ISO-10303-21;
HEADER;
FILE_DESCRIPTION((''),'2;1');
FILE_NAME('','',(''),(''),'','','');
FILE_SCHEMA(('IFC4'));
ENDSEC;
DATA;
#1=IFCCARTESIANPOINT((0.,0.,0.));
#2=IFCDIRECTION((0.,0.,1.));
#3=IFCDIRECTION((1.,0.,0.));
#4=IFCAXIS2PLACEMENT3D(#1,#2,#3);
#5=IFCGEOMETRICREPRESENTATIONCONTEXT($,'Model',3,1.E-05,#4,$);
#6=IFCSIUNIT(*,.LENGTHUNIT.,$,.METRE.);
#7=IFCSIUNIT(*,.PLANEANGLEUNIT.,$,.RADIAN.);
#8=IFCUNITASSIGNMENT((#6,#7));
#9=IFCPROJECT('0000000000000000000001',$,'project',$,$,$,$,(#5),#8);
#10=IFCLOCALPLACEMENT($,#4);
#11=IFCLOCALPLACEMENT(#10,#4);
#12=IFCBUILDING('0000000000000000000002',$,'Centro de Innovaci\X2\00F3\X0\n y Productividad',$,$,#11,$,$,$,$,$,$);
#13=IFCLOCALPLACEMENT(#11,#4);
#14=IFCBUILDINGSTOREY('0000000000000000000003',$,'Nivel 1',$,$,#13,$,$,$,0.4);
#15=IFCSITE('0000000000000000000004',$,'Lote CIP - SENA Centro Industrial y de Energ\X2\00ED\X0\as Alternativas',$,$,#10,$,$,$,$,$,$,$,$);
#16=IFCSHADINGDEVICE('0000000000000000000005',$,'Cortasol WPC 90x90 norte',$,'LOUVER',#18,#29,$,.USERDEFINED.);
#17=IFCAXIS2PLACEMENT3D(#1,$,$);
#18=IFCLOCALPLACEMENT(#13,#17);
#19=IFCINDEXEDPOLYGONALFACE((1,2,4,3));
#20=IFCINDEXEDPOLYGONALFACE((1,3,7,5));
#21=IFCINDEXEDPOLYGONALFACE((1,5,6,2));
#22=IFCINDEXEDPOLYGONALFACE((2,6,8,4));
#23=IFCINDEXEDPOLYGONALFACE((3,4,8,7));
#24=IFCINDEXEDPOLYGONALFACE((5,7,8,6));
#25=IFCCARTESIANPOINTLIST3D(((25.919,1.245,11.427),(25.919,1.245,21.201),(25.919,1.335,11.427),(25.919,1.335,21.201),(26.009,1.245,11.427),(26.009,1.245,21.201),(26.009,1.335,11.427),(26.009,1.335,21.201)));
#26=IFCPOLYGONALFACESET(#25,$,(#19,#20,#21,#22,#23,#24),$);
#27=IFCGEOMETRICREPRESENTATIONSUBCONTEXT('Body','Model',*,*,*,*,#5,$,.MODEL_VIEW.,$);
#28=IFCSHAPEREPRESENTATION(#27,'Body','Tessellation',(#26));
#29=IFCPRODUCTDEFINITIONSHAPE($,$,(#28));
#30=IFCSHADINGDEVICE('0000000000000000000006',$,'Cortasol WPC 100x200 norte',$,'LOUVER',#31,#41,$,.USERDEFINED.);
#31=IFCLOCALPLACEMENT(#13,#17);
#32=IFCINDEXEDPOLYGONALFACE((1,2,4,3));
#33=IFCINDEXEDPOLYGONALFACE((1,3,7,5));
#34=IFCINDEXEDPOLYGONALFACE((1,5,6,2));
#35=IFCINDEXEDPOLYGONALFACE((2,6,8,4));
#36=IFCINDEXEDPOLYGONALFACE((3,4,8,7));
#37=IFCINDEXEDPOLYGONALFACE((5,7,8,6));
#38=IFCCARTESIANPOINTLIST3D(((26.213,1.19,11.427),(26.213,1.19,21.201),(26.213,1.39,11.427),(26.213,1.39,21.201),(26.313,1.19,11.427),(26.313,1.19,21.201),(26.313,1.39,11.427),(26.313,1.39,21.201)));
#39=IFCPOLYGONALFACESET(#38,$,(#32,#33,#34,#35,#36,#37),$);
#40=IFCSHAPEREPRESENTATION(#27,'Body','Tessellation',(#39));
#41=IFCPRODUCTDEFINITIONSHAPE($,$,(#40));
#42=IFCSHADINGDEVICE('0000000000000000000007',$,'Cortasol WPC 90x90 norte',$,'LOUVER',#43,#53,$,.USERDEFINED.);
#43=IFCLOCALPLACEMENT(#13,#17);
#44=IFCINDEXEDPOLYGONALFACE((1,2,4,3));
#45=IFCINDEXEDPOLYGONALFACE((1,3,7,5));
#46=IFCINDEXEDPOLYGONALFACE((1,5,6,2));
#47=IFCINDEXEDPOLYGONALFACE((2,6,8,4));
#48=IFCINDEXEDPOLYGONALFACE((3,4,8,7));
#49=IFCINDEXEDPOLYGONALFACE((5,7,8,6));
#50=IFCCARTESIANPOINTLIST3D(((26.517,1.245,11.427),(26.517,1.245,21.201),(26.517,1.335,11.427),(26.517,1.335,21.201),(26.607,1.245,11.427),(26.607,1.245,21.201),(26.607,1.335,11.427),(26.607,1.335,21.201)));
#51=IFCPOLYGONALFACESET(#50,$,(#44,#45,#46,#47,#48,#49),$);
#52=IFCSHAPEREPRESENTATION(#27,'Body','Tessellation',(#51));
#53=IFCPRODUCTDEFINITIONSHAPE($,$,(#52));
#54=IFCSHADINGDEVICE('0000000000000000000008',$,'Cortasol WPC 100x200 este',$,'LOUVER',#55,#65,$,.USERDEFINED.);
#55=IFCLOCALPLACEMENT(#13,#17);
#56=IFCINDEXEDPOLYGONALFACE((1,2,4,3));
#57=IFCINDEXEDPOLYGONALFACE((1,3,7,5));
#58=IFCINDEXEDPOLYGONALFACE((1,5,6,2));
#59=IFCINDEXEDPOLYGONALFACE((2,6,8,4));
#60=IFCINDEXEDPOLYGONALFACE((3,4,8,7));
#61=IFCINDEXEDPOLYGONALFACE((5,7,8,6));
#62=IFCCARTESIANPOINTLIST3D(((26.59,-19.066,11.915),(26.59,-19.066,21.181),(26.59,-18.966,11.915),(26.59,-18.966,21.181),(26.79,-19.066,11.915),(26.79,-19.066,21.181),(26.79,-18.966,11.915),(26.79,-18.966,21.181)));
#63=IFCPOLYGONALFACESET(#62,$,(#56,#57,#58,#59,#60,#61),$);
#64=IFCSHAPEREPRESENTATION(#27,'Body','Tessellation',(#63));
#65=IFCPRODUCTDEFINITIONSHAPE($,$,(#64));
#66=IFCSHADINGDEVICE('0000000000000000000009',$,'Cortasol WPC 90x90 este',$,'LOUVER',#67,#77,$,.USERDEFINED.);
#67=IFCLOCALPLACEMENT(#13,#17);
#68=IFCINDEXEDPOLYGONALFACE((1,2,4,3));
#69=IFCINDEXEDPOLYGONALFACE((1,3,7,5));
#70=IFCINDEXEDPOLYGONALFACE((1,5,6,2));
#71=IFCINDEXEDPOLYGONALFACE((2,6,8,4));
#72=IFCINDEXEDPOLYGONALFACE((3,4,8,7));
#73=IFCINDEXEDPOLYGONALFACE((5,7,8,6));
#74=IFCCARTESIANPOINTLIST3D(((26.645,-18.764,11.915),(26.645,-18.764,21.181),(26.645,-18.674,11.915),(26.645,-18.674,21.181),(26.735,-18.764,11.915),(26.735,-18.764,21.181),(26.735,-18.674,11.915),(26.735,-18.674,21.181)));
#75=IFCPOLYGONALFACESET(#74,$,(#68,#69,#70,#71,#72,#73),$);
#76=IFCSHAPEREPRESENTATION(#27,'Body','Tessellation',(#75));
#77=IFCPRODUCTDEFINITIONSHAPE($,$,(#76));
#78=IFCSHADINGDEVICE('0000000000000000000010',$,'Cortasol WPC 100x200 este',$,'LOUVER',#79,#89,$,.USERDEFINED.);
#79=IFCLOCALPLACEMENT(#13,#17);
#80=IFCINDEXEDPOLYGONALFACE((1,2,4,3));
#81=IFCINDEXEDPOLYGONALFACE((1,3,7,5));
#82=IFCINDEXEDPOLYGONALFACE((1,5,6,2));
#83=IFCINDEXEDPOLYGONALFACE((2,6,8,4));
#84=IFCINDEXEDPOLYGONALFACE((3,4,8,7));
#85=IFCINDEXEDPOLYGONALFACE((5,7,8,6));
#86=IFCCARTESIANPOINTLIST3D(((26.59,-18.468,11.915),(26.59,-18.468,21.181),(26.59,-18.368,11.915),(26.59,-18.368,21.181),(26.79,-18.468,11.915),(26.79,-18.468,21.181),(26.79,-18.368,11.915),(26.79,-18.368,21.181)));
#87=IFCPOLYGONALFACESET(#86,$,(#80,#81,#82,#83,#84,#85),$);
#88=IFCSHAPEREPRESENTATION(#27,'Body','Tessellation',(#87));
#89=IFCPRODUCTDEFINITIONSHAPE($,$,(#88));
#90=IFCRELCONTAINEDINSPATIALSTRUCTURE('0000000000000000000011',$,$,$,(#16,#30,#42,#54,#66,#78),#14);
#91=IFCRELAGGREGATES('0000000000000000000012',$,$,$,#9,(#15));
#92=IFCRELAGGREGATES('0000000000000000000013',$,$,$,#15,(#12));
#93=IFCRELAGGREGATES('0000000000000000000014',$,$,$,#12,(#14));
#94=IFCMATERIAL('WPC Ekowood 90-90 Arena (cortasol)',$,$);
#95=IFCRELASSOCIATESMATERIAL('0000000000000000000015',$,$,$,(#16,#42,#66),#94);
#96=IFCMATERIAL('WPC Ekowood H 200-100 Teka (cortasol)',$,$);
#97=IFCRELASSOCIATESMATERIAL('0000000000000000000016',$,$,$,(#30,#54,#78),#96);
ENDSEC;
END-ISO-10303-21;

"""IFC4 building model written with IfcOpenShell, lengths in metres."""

from ifc_helpers import new_model, si_unit, frame, origin_with_axes, place, context, subcontext, project, spatial, polyline, outline, extrude, material, element, save


model = new_model("IFC4")

# Units and contexts
model_context = context("Model", 3, precision=1e-05, world=origin_with_axes())
body_context = subcontext(model_context, "Body", "Model", "MODEL_VIEW")
ifc_project = project(units=[si_unit("LENGTHUNIT", "METRE"), si_unit("PLANEANGLEUNIT", "RADIAN")], contexts=[model_context])

# Site, building, storey
site_placement = place(None, origin_with_axes())
site = spatial("IfcSite", under=ifc_project, at=site_placement, Name="Lote CIP - SENA Centro Industrial y de Energías Alternativas")
building_placement = place(site_placement, origin_with_axes())
building = spatial("IfcBuilding", under=site, at=building_placement, Name="Centro de Innovación y Productividad")
storey_placement = place(building_placement, origin_with_axes())
storey = spatial("IfcBuildingStorey", under=building, at=storey_placement, Name="Nivel 1", Elevation=0.4)

# Shading devices
ifc_material_1 = material(Name="WPC Ekowood H 200-100 Teka (cortasol)")
ifc_material_2 = material(Name="WPC Ekowood 90-90 Arena (cortasol)")
shading_device_1_placement = place(storey_placement, origin_with_axes())
element("IfcShadingDevice", 1, at=shading_device_1_placement, inside=storey, material=ifc_material_2, Name="Cortasol WPC 90x90 norte", ObjectType="LOUVER", PredefinedType="USERDEFINED", context=body_context, shape_type="SweptSolid", body=[
    extrude(outline(polyline([(25.919, 1.245), (25.919, 1.335), (26.009, 1.335), (26.009, 1.245), (25.919, 1.245)])), frame((0.0, 0.0, 11.427)), (0.0, 0.0, 1.0), 9.774),
])
shading_device_2_placement = place(storey_placement, origin_with_axes())
element("IfcShadingDevice", 2, at=shading_device_2_placement, inside=storey, material=ifc_material_1, Name="Cortasol WPC 100x200 norte", ObjectType="LOUVER", PredefinedType="USERDEFINED", context=body_context, shape_type="SweptSolid", body=[
    extrude(outline(polyline([(26.213, 1.19), (26.213, 1.39), (26.313, 1.39), (26.313, 1.19), (26.213, 1.19)])), frame((0.0, 0.0, 11.427)), (0.0, 0.0, 1.0), 9.774),
])
shading_device_3_placement = place(storey_placement, origin_with_axes())
element("IfcShadingDevice", 3, at=shading_device_3_placement, inside=storey, material=ifc_material_2, Name="Cortasol WPC 90x90 norte", ObjectType="LOUVER", PredefinedType="USERDEFINED", context=body_context, shape_type="SweptSolid", body=[
    extrude(outline(polyline([(26.517, 1.245), (26.517, 1.335), (26.607, 1.335), (26.607, 1.245), (26.517, 1.245)])), frame((0.0, 0.0, 11.427)), (0.0, 0.0, 1.0), 9.774),
])
shading_device_4_placement = place(storey_placement, origin_with_axes())
element("IfcShadingDevice", 4, at=shading_device_4_placement, inside=storey, material=ifc_material_1, Name="Cortasol WPC 100x200 este", ObjectType="LOUVER", PredefinedType="USERDEFINED", context=body_context, shape_type="SweptSolid", body=[
    extrude(outline(polyline([(26.79, -19.066), (26.59, -19.066), (26.59, -18.966), (26.79, -18.966), (26.79, -19.066)])), frame((0.0, 0.0, 11.915)), (0.0, 0.0, 1.0), 9.266),
])
shading_device_5_placement = place(storey_placement, origin_with_axes())
element("IfcShadingDevice", 5, at=shading_device_5_placement, inside=storey, material=ifc_material_2, Name="Cortasol WPC 90x90 este", ObjectType="LOUVER", PredefinedType="USERDEFINED", context=body_context, shape_type="SweptSolid", body=[
    extrude(outline(polyline([(26.735, -18.764), (26.645, -18.764), (26.645, -18.674), (26.735, -18.674), (26.735, -18.764)])), frame((0.0, 0.0, 11.915)), (0.0, 0.0, 1.0), 9.266),
])
shading_device_6_placement = place(storey_placement, origin_with_axes())
element("IfcShadingDevice", 6, at=shading_device_6_placement, inside=storey, material=ifc_material_1, Name="Cortasol WPC 100x200 este", ObjectType="LOUVER", PredefinedType="USERDEFINED", context=body_context, shape_type="SweptSolid", body=[
    extrude(outline(polyline([(26.79, -18.468), (26.59, -18.468), (26.59, -18.368), (26.79, -18.368), (26.79, -18.468)])), frame((0.0, 0.0, 11.915)), (0.0, 0.0, 1.0), 9.266),
])

save(model, "model.ifc")
